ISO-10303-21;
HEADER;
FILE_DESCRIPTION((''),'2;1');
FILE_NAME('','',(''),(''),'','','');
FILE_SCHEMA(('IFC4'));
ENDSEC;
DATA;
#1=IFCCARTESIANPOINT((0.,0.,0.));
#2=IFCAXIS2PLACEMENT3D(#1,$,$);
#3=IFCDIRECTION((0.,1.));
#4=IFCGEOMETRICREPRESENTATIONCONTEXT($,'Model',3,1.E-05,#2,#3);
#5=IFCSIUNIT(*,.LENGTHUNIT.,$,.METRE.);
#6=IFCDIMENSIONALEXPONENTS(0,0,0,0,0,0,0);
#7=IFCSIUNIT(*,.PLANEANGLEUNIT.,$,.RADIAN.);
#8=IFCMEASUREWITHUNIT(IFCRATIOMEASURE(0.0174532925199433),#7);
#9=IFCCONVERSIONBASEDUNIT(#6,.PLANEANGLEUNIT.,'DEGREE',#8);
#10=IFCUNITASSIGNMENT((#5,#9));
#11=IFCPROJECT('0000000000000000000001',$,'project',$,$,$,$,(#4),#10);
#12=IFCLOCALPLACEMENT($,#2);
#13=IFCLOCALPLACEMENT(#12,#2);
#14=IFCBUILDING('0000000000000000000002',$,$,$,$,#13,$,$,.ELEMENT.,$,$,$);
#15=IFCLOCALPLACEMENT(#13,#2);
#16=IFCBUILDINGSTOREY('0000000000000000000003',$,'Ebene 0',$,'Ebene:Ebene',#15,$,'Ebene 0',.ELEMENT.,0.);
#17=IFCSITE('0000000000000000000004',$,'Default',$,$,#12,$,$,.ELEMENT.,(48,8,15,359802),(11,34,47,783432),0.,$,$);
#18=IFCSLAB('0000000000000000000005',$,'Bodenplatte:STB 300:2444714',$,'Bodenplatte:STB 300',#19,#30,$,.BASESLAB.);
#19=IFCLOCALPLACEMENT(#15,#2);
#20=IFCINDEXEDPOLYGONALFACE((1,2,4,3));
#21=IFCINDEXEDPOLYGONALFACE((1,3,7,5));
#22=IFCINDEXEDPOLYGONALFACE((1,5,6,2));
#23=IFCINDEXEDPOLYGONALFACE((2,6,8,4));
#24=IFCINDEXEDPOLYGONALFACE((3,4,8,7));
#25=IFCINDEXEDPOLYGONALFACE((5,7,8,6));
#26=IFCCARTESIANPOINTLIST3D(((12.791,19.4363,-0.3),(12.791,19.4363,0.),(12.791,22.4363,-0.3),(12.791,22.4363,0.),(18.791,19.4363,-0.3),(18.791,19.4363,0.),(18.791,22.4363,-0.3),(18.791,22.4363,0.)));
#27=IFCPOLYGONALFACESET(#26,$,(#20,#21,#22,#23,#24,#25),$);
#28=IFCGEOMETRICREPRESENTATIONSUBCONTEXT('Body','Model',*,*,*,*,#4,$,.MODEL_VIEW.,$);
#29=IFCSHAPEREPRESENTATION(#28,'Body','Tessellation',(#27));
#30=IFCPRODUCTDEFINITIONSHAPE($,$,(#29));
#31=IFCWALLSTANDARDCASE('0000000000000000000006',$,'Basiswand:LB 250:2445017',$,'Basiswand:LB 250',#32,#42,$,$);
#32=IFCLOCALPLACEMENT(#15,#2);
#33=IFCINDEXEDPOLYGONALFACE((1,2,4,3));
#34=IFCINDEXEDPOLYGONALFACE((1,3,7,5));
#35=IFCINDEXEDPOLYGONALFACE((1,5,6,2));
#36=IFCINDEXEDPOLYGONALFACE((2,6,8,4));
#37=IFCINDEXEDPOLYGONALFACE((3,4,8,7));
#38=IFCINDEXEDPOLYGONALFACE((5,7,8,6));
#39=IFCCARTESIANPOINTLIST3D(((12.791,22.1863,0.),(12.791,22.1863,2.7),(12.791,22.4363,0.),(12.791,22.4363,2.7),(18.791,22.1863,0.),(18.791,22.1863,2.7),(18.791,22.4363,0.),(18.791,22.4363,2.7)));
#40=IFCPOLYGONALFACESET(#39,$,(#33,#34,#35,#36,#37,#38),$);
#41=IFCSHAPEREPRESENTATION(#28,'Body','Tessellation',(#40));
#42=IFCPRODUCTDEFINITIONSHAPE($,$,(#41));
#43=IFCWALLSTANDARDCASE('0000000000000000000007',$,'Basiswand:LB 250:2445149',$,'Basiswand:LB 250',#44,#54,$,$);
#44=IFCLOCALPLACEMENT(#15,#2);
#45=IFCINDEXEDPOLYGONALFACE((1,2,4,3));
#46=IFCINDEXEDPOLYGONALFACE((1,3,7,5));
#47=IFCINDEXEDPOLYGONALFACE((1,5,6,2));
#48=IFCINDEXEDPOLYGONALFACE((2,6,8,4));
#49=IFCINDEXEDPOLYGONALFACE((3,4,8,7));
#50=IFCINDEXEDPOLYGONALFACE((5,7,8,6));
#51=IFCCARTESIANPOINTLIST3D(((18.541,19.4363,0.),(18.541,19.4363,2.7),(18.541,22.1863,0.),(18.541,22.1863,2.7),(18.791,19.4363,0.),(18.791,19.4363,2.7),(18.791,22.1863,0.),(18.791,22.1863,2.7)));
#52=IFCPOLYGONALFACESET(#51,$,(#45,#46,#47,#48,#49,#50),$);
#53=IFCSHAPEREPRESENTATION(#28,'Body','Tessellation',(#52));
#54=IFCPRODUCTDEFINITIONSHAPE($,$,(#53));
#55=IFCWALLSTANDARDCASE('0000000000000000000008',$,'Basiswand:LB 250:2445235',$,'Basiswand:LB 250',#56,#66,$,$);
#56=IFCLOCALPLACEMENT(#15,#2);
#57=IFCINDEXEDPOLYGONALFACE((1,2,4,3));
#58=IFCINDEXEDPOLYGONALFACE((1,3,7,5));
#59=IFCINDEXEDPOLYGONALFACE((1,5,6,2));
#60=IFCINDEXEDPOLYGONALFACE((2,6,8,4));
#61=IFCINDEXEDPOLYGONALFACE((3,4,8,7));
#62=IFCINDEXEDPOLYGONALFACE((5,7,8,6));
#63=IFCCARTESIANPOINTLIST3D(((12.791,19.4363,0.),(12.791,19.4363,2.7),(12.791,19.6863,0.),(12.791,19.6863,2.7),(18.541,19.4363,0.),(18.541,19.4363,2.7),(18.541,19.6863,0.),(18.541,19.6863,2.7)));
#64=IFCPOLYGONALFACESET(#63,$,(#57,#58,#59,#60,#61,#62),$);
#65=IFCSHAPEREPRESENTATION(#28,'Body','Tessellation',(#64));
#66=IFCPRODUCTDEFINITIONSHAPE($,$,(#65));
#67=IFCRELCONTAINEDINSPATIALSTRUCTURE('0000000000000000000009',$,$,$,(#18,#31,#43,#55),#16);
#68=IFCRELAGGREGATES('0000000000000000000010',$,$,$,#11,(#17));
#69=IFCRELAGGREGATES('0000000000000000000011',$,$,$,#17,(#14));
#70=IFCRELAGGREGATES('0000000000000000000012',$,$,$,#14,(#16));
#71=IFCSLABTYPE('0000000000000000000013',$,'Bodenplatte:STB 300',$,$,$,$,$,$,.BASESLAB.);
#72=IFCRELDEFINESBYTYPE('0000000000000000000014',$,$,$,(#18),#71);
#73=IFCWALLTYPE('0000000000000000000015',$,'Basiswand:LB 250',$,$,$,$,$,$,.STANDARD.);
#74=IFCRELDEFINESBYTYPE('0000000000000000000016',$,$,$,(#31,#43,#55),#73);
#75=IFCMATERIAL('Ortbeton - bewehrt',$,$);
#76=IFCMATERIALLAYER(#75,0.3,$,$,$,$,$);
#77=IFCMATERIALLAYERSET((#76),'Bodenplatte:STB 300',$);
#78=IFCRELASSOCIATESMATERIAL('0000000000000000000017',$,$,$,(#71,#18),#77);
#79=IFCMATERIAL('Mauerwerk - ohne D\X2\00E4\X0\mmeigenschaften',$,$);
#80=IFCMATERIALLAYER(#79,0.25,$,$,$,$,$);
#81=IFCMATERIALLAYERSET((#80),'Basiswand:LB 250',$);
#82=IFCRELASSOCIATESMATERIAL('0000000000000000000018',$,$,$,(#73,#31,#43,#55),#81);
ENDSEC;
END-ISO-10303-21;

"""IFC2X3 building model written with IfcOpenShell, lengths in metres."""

from ifc_helpers import new_model, entity, si_unit, converted_unit, direction, frame, frame_2d, origin, place, context, subcontext, project, spatial, polyline, rectangle, extrude, clip, bounded_halfspace, material, layer, layer_set, layer_usage, type_object, element, save


model = new_model("IFC2X3")

# Units and contexts
model_context = context("Model", 3, precision=1e-05, world=origin(), true_north=direction((0.0, 1.0)))
body_context = subcontext(model_context, "Body", "Model", "MODEL_VIEW")
ifc_project = project(units=[si_unit("LENGTHUNIT", "METRE"), converted_unit("PLANEANGLEUNIT", "DEGREE", entity("IfcRatioMeasure", 0.0174532925199433), si_unit("PLANEANGLEUNIT", "RADIAN"), dimensions=[0, 0, 0, 0, 0, 0, 0])], contexts=[model_context])

# Site, building, storey
site_placement = place(None, origin())
site = spatial("IfcSite", under=ifc_project, at=site_placement, Name="Default", CompositionType="ELEMENT", RefLatitude=(48, 8, 15, 359802), RefLongitude=(11, 34, 47, 783432), RefElevation=0.0)
building_placement = place(site_placement, origin())
building = spatial("IfcBuilding", under=site, at=building_placement, CompositionType="ELEMENT")
storey_placement = place(building_placement, origin())
storey = spatial("IfcBuildingStorey", under=building, at=storey_placement, Name="Ebene 0", ObjectType="Ebene:Ebene", LongName="Ebene 0", CompositionType="ELEMENT", Elevation=0.0)

# Slab
ifc_material_1 = material(Name="Ortbeton - bewehrt")
ifc_layer_1 = layer(ifc_material_1, 0.3)
ifc_layer_set_1 = layer_set([ifc_layer_1], Name="Bodenplatte:STB 300")
ifc_layer_usage_1 = layer_usage(ifc_layer_set_1, "AXIS3", "POSITIVE", 0.0)
slab_type = type_object("IfcSlabType", Name="Bodenplatte:STB 300", PredefinedType="BASESLAB", material=ifc_layer_set_1)
slab_placement = place(storey_placement, origin())
element("IfcSlab", 1, at=slab_placement, inside=storey, type_object=slab_type, material=ifc_layer_usage_1, Name="Bodenplatte:STB 300:2444714", ObjectType="Bodenplatte:STB 300", PredefinedType="BASESLAB", context=body_context, shape_type="SweptSolid", body=[
    extrude(rectangle(XDim=3.0, YDim=6.0, at=frame_2d((0.0, 0.0), x_axis=(1.0, 0.0))), frame((15.791, 20.9363, 0.0), z_axis=(0.0, 0.0, -1.0), x_axis=(0.0, 1.0, 0.0)), (0.0, 0.0, 1.0), 0.3),
])

# Walls
ifc_material_2 = material(Name="Mauerwerk - ohne Dämmeigenschaften")
ifc_layer_2 = layer(ifc_material_2, 0.25)
ifc_layer_set_2 = layer_set([ifc_layer_2], Name="Basiswand:LB 250")
ifc_layer_usage_2 = layer_usage(ifc_layer_set_2, "AXIS2", "NEGATIVE", 0.125)
wall_type = type_object("IfcWallType", Name="Basiswand:LB 250", PredefinedType="STANDARD", material=ifc_layer_set_2)
wall_1_placement = place(storey_placement, frame((12.791, 22.3113, 0.0)))
element("IfcWallStandardCase", 2, at=wall_1_placement, inside=storey, type_object=wall_type, material=ifc_layer_usage_2, Name="Basiswand:LB 250:2445017", ObjectType="Basiswand:LB 250", context=body_context, shape_type="Clipping", body=[
    clip(extrude(rectangle(XDim=6.0, YDim=0.25, at=frame_2d((3.0, 0.0), x_axis=(-1.0, 0.0))), origin(), (0.0, 0.0, 1.0), 2.7), bounded_halfspace(frame((0.0, -0.125, 2.7), z_axis=(0.0, 0.0, -1.0), x_axis=(0.0, -1.0, 0.0)), True, frame((0.0, -0.125, 2.7)), polyline([(0.0, 0.0), (5.75, 0.0), (6.0, 0.0), (6.0, 0.25), (0.0, 0.25), (0.0, 0.0)]))),
])
ifc_layer_usage_3 = layer_usage(ifc_layer_set_2, "AXIS2", "NEGATIVE", 0.125)
wall_2_placement = place(storey_placement, frame((18.666, 22.1863, 0.0), z_axis=(0.0, 0.0, 1.0), x_axis=(0.0, -1.0, 0.0)))
element("IfcWallStandardCase", 3, at=wall_2_placement, inside=storey, type_object=wall_type, material=ifc_layer_usage_3, Name="Basiswand:LB 250:2445149", ObjectType="Basiswand:LB 250", context=body_context, shape_type="Clipping", body=[
    clip(extrude(rectangle(XDim=2.75, YDim=0.25, at=frame_2d((1.375, 0.0), x_axis=(-1.0, 0.0))), origin(), (0.0, 0.0, 1.0), 2.7), bounded_halfspace(frame((0.0, -0.125, 2.7), z_axis=(0.0, 0.0, -1.0), x_axis=(1.0, 0.0, 0.0)), True, frame((0.0, -0.125, 2.7)), polyline([(0.0, 0.0), (2.5, 0.0), (2.75, 0.0), (2.75, 0.25), (0.0, 0.25), (0.0, 0.0)]))),
])
ifc_layer_usage_4 = layer_usage(ifc_layer_set_2, "AXIS2", "NEGATIVE", 0.125)
wall_3_placement = place(storey_placement, frame((18.541, 19.5613, 0.0), z_axis=(0.0, 0.0, 1.0), x_axis=(-1.0, 0.0, 0.0)))
element("IfcWallStandardCase", 4, at=wall_3_placement, inside=storey, type_object=wall_type, material=ifc_layer_usage_4, Name="Basiswand:LB 250:2445235", ObjectType="Basiswand:LB 250", context=body_context, shape_type="Clipping", body=[
    clip(extrude(rectangle(XDim=5.75, YDim=0.25, at=frame_2d((2.875, 0.0), x_axis=(-1.0, 0.0))), origin(), (0.0, 0.0, 1.0), 2.7), bounded_halfspace(frame((0.0, -0.125, 2.7), z_axis=(0.0, 0.0, -1.0), x_axis=(0.0, 1.0, 0.0)), True, frame((0.0, -0.125, 2.7)), polyline([(0.0, 0.0), (5.75, 0.0), (5.75, 0.25), (0.0, 0.25), (0.0, 0.0)]))),
])

save(model, "model.ifc")
